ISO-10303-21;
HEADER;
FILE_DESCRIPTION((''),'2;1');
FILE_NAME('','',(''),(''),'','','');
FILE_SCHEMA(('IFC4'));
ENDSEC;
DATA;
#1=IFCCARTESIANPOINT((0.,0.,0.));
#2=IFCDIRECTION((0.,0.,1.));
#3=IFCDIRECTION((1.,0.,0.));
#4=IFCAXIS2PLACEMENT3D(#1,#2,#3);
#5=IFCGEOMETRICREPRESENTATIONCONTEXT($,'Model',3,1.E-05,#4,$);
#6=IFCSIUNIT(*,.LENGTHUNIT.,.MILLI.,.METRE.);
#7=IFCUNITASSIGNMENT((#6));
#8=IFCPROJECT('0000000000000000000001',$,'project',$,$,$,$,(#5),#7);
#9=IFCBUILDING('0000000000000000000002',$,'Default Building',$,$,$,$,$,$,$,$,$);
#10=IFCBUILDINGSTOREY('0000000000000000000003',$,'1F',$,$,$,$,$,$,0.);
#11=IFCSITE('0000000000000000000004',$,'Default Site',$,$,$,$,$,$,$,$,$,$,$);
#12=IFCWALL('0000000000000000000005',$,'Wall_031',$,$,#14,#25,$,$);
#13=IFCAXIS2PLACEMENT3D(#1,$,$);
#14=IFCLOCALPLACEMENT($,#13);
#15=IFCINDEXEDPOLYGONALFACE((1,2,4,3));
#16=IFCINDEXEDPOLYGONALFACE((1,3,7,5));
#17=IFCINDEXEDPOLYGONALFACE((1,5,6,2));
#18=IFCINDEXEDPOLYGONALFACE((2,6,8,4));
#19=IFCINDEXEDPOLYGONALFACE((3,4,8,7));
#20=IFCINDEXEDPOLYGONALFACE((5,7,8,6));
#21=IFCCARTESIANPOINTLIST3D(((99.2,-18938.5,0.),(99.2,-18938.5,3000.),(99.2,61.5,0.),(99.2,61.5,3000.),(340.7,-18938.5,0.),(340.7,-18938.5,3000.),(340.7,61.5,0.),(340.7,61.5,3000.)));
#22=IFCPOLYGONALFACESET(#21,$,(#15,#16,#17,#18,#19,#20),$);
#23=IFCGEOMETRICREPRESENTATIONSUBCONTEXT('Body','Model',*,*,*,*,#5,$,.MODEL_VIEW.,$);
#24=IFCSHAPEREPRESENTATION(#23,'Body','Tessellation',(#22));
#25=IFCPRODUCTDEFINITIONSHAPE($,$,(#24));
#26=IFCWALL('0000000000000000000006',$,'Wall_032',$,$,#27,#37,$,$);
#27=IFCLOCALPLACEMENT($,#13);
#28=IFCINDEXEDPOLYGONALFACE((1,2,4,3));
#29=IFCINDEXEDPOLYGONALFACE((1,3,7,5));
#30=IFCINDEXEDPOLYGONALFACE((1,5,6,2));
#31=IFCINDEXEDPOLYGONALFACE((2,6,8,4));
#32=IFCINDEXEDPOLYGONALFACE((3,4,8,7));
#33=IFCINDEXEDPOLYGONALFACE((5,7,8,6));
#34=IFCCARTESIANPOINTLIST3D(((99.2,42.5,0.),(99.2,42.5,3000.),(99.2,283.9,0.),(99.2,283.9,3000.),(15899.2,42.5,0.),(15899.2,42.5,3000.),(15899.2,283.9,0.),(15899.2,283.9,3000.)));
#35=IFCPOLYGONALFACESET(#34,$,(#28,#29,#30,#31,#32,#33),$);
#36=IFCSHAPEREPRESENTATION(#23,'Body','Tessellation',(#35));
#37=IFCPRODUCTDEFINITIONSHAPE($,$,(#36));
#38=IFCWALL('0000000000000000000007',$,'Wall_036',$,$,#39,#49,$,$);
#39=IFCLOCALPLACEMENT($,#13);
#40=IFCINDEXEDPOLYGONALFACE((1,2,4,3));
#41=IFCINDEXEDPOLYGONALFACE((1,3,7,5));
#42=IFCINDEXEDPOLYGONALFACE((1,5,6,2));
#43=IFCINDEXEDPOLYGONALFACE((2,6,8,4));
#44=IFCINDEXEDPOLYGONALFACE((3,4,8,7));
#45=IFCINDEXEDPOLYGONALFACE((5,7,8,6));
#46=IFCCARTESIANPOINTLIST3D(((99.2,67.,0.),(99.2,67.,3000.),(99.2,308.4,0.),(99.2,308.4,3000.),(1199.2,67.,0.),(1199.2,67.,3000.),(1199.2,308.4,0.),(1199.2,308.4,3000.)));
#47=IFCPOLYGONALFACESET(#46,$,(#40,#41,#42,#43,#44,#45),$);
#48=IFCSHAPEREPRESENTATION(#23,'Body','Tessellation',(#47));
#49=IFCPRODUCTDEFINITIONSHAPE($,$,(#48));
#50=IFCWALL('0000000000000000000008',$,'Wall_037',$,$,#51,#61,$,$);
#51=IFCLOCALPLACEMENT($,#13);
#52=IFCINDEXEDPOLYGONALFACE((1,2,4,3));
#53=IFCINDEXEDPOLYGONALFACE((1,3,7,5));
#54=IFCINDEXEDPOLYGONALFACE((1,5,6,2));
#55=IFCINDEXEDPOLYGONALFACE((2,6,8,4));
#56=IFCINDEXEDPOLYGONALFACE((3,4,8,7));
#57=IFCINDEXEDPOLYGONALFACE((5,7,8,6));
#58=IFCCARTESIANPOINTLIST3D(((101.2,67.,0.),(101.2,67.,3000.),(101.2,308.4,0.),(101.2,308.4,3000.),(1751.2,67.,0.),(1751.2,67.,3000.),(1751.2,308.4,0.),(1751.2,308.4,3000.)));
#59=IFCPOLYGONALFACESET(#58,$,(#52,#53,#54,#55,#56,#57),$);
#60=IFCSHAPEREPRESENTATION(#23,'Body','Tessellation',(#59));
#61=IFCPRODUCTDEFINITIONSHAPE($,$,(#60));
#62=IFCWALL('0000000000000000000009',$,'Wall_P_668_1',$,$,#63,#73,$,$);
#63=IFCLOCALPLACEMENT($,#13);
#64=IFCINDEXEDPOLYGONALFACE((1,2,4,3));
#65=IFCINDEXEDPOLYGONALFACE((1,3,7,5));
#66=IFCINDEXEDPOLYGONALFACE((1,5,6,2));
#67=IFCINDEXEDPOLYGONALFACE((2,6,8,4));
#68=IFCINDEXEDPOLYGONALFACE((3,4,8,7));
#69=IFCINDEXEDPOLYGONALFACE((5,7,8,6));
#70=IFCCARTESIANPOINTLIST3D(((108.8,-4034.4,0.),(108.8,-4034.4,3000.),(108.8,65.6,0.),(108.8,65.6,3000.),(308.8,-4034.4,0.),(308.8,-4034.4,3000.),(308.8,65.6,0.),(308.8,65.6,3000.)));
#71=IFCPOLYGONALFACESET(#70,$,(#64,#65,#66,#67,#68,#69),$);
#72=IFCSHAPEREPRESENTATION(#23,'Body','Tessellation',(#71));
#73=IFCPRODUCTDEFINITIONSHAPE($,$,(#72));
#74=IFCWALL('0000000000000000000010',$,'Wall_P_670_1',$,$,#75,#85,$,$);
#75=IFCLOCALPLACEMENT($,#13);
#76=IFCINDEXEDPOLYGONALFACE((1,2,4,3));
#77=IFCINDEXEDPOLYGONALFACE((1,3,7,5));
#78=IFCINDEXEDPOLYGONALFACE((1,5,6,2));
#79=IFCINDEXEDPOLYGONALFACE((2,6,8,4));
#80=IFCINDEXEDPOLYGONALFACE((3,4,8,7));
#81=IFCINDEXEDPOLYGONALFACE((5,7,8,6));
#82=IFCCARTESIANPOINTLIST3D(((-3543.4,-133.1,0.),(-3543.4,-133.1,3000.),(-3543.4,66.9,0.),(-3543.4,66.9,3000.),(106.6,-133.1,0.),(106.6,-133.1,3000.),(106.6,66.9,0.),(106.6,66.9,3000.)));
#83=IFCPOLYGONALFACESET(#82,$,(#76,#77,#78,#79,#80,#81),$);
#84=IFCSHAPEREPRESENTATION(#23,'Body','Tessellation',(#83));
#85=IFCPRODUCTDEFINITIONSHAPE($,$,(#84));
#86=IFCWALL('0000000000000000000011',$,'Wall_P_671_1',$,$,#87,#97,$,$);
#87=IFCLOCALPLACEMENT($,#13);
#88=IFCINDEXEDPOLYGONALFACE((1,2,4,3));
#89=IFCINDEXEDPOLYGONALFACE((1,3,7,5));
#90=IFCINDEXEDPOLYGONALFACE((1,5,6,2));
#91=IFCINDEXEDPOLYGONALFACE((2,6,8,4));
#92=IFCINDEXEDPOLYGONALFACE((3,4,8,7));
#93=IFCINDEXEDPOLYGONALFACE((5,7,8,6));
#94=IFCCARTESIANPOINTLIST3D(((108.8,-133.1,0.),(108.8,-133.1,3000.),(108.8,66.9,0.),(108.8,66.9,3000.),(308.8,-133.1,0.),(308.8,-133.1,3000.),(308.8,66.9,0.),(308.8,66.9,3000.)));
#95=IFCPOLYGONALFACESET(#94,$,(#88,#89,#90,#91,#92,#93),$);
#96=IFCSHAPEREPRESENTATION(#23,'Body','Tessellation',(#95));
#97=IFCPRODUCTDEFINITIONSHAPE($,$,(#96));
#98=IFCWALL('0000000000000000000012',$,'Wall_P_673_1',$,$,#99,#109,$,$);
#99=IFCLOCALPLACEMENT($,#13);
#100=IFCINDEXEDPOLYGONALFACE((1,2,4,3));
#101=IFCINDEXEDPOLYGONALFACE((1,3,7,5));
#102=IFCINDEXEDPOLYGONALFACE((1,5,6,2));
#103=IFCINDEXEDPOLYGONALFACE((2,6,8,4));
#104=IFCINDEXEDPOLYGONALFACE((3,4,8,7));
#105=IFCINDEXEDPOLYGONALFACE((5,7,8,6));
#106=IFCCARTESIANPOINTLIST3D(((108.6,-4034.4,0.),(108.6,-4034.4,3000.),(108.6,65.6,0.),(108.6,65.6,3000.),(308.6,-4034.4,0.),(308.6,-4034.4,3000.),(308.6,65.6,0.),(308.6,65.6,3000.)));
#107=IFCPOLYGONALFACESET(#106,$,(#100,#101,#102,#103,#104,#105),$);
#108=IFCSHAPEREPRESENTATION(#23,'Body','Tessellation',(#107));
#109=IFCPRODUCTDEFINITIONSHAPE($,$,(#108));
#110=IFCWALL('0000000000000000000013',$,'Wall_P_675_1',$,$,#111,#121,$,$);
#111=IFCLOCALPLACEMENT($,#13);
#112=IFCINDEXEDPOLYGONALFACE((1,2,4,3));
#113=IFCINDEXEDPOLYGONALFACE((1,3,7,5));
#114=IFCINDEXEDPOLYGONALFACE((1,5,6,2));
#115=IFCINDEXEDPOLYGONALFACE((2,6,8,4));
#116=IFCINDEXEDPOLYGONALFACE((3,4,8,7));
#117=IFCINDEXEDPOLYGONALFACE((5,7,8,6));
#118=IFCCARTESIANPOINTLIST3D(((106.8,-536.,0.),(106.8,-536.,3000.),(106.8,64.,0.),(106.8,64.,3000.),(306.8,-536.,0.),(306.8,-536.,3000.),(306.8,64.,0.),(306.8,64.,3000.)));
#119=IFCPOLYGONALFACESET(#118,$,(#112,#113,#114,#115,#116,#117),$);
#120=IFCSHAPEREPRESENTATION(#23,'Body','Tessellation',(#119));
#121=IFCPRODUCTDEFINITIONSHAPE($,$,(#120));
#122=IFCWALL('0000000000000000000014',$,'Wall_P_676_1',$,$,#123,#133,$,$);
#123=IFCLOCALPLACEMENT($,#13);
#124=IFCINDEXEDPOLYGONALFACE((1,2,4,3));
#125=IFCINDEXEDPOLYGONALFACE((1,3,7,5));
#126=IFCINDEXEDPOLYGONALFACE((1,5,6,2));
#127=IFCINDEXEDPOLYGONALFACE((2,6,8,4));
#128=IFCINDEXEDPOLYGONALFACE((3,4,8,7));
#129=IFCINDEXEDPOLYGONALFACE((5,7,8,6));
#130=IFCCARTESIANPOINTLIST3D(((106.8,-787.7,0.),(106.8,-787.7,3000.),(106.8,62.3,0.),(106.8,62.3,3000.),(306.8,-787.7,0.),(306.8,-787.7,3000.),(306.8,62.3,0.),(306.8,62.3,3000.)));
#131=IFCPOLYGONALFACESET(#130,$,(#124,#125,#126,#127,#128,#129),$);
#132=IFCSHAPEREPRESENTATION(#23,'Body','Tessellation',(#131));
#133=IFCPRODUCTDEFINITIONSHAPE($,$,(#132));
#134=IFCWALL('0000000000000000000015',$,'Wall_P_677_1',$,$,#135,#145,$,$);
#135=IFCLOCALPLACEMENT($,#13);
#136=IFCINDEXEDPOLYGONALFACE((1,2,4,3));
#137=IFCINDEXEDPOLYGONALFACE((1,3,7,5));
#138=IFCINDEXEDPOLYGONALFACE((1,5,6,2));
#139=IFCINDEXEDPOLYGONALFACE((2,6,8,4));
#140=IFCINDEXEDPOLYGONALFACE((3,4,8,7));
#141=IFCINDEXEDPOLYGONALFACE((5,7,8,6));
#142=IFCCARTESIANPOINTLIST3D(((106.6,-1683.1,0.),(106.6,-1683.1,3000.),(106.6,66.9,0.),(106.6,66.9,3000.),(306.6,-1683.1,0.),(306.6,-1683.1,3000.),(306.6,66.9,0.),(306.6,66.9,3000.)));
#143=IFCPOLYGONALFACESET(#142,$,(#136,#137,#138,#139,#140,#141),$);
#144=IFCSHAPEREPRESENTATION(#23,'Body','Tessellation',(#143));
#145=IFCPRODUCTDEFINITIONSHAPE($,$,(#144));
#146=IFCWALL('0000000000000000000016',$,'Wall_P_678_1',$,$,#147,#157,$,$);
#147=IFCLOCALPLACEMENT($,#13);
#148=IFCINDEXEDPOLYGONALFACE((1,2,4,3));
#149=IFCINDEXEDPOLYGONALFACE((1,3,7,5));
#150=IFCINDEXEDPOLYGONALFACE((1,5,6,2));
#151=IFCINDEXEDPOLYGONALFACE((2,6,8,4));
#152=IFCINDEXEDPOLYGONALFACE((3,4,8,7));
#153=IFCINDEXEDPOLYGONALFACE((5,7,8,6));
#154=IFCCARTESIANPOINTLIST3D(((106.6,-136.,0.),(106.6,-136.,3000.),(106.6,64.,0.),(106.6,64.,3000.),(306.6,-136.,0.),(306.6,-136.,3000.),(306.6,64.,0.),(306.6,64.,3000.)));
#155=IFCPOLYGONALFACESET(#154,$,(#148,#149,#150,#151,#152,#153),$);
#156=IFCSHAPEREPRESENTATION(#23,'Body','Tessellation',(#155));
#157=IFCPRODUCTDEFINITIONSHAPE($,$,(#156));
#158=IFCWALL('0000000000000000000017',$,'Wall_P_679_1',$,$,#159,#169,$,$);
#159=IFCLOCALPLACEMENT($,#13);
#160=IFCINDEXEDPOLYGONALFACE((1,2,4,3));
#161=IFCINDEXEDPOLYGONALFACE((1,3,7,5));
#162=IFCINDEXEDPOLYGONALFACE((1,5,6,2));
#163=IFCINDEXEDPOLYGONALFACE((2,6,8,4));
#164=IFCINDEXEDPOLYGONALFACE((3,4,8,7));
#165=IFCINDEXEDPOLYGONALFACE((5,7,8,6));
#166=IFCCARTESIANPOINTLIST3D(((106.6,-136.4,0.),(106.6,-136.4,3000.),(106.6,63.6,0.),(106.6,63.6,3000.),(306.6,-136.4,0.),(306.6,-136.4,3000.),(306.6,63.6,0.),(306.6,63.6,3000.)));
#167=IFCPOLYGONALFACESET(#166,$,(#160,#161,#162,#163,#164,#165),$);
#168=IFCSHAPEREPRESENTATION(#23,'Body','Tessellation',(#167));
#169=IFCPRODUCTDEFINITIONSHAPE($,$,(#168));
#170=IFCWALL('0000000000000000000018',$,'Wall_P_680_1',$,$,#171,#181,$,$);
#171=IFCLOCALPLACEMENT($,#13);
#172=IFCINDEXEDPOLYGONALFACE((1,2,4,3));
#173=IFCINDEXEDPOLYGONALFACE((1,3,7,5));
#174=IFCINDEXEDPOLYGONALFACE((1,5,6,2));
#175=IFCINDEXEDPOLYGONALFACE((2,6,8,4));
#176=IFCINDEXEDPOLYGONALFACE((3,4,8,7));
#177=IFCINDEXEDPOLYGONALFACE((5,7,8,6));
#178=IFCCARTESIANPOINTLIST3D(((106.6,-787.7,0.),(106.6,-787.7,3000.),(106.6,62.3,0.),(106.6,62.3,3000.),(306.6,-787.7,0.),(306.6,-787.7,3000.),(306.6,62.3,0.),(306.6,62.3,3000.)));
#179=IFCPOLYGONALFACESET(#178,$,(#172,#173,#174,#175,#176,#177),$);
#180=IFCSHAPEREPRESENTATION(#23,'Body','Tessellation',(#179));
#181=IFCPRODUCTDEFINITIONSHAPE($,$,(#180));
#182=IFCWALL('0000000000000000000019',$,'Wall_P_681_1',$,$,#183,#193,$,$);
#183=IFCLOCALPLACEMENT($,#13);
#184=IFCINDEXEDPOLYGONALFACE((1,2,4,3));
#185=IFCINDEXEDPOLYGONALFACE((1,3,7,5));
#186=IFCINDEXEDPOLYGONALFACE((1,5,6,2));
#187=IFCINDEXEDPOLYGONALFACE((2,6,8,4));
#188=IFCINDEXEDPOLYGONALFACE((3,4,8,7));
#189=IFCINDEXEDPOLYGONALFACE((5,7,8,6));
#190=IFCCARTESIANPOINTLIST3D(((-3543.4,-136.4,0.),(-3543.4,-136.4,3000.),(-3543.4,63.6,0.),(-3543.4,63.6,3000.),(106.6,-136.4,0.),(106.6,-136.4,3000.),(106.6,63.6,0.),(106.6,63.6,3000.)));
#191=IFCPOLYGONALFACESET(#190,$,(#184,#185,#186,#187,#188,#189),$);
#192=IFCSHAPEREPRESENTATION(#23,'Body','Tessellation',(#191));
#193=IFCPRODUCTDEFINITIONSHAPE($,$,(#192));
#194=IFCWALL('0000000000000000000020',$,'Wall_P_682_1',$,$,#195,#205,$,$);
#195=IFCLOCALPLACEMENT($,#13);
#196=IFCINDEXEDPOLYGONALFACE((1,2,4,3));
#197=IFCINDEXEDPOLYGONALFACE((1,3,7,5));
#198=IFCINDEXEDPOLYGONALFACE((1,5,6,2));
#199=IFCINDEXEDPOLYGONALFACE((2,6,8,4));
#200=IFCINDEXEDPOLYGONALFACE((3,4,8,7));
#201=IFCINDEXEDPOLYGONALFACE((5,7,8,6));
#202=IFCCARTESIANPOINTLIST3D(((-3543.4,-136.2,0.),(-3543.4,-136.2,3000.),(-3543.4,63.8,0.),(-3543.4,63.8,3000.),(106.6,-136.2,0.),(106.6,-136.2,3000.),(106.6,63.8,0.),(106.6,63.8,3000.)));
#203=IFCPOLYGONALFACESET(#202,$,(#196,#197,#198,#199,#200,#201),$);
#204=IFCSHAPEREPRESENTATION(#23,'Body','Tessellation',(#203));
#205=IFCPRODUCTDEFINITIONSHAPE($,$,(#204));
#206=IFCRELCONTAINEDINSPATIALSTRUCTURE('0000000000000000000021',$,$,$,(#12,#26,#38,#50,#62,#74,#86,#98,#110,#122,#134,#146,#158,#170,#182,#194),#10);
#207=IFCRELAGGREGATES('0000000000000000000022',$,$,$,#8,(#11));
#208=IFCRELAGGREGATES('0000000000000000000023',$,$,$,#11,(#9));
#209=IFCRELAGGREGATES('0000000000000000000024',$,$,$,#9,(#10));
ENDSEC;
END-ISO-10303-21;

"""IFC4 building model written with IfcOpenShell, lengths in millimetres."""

from ifc_helpers import new_model, si_unit, frame, origin_with_axes, place, context, subcontext, project, spatial, indexed_curve, outline, extrude, element, save


model = new_model("IFC4")

# Units and contexts
model_context = context("Model", 3, precision=1e-05, world=origin_with_axes())
body_context = subcontext(model_context, "Body", "Model", "MODEL_VIEW")
ifc_project = project(units=[si_unit("LENGTHUNIT", "METRE", prefix="MILLI")], contexts=[model_context])

# Site, building, storey
site = spatial("IfcSite", under=ifc_project, Name="Default Site")
building = spatial("IfcBuilding", under=site, Name="Default Building")
storey = spatial("IfcBuildingStorey", under=building, Name="1F", Elevation=0.0)

# Walls
wall_1_placement = place(None, frame((99.2, 61.5, 0.0), z_axis=(0.0, 0.0, 1.0), x_axis=(0.0, -1.0, 0.0)))
element("IfcWall", 1, at=wall_1_placement, inside=storey, Name="Wall_031", context=body_context, shape_type="SweptSolid", body=[
    extrude(outline(indexed_curve([(0.0, 0.0), (0.0, 241.4), (19000.0, 241.4), (19000.0, 0.0), (0.0, 0.0)], self_intersect=False)), origin_with_axes(), (0.0, 0.0, 1.0), 3000.0),
])
wall_2_placement = place(None, frame((99.2, 42.5, 0.0), z_axis=(0.0, 0.0, 1.0), x_axis=(1.0, 0.0, 0.0)))
element("IfcWall", 2, at=wall_2_placement, inside=storey, Name="Wall_032", context=body_context, shape_type="SweptSolid", body=[
    extrude(outline(indexed_curve([(0.0, 0.0), (0.0, 241.4), (15800.0, 241.4), (15800.0, 0.0), (0.0, 0.0)], self_intersect=False)), origin_with_axes(), (0.0, 0.0, 1.0), 3000.0),
])
wall_3_placement = place(None, frame((99.2, 67.0, 0.0), z_axis=(0.0, 0.0, 1.0), x_axis=(1.0, 0.0, 0.0)))
element("IfcWall", 3, at=wall_3_placement, inside=storey, Name="Wall_036", context=body_context, shape_type="SweptSolid", body=[
    extrude(outline(indexed_curve([(0.0, 0.0), (0.0, 241.4), (1100.0, 241.4), (1100.0, 0.0), (0.0, 0.0)], self_intersect=False)), origin_with_axes(), (0.0, 0.0, 1.0), 3000.0),
])
wall_4_placement = place(None, frame((101.2, 67.0, 0.0), z_axis=(0.0, 0.0, 1.0), x_axis=(1.0, 0.0, 0.0)))
element("IfcWall", 4, at=wall_4_placement, inside=storey, Name="Wall_037", context=body_context, shape_type="SweptSolid", body=[
    extrude(outline(indexed_curve([(0.0, 0.0), (0.0, 241.4), (1650.0, 241.4), (1650.0, 0.0), (0.0, 0.0)], self_intersect=False)), origin_with_axes(), (0.0, 0.0, 1.0), 3000.0),
])
wall_5_placement = place(None, frame((108.8, 65.6, 0.0), z_axis=(0.0, 0.0, 1.0), x_axis=(0.0, -1.0, 0.0)))
element("IfcWall", 5, at=wall_5_placement, inside=storey, Name="Wall_P_668_1", context=body_context, shape_type="SweptSolid", body=[
    extrude(outline(indexed_curve([(0.0, 0.0), (0.0, 200.0), (4100.0, 200.0), (4100.0, 0.0), (0.0, 0.0)], self_intersect=False)), origin_with_axes(), (0.0, 0.0, 1.0), 3000.0),
])
wall_6_placement = place(None, frame((106.6, 66.9, 0.0), z_axis=(0.0, 0.0, 1.0), x_axis=(-1.0, 0.0, 0.0)))
element("IfcWall", 6, at=wall_6_placement, inside=storey, Name="Wall_P_670_1", context=body_context, shape_type="SweptSolid", body=[
    extrude(outline(indexed_curve([(0.0, 0.0), (0.0, 200.0), (3650.0, 200.0), (3650.0, 0.0), (0.0, 0.0)], self_intersect=False)), origin_with_axes(), (0.0, 0.0, 1.0), 3000.0),
])
wall_7_placement = place(None, frame((108.8, 66.9, 0.0), z_axis=(0.0, 0.0, 1.0), x_axis=(0.0, -1.0, 0.0)))
element("IfcWall", 7, at=wall_7_placement, inside=storey, Name="Wall_P_671_1", context=body_context, shape_type="SweptSolid", body=[
    extrude(outline(indexed_curve([(0.0, 0.0), (0.0, 200.0), (200.0, 200.0), (200.0, 0.0), (0.0, 0.0)], self_intersect=False)), origin_with_axes(), (0.0, 0.0, 1.0), 3000.0),
])
wall_8_placement = place(None, frame((108.6, 65.6, 0.0), z_axis=(0.0, 0.0, 1.0), x_axis=(0.0, -1.0, 0.0)))
element("IfcWall", 8, at=wall_8_placement, inside=storey, Name="Wall_P_673_1", context=body_context, shape_type="SweptSolid", body=[
    extrude(outline(indexed_curve([(0.0, 0.0), (0.0, 200.0), (4100.0, 200.0), (4100.0, 0.0), (0.0, 0.0)], self_intersect=False)), origin_with_axes(), (0.0, 0.0, 1.0), 3000.0),
])
wall_9_placement = place(None, frame((106.8, 64.0, 0.0), z_axis=(0.0, 0.0, 1.0), x_axis=(0.0, -1.0, 0.0)))
element("IfcWall", 9, at=wall_9_placement, inside=storey, Name="Wall_P_675_1", context=body_context, shape_type="SweptSolid", body=[
    extrude(outline(indexed_curve([(0.0, 0.0), (0.0, 200.0), (600.0, 200.0), (600.0, 0.0), (0.0, 0.0)], self_intersect=False)), origin_with_axes(), (0.0, 0.0, 1.0), 3000.0),
])
wall_10_placement = place(None, frame((106.8, 62.3, 0.0), z_axis=(0.0, 0.0, 1.0), x_axis=(0.0, -1.0, 0.0)))
element("IfcWall", 10, at=wall_10_placement, inside=storey, Name="Wall_P_676_1", context=body_context, shape_type="SweptSolid", body=[
    extrude(outline(indexed_curve([(0.0, 0.0), (0.0, 200.0), (850.0, 200.0), (850.0, 0.0), (0.0, 0.0)], self_intersect=False)), origin_with_axes(), (0.0, 0.0, 1.0), 3000.0),
])
wall_11_placement = place(None, frame((106.6, 66.9, 0.0), z_axis=(0.0, 0.0, 1.0), x_axis=(0.0, -1.0, 0.0)))
element("IfcWall", 11, at=wall_11_placement, inside=storey, Name="Wall_P_677_1", context=body_context, shape_type="SweptSolid", body=[
    extrude(outline(indexed_curve([(0.0, 0.0), (0.0, 200.0), (1750.0, 200.0), (1750.0, 0.0), (0.0, 0.0)], self_intersect=False)), origin_with_axes(), (0.0, 0.0, 1.0), 3000.0),
])
wall_12_placement = place(None, frame((106.6, 64.0, 0.0), z_axis=(0.0, 0.0, 1.0), x_axis=(0.0, -1.0, 0.0)))
element("IfcWall", 12, at=wall_12_placement, inside=storey, Name="Wall_P_678_1", context=body_context, shape_type="SweptSolid", body=[
    extrude(outline(indexed_curve([(0.0, 0.0), (0.0, 200.0), (200.0, 200.0), (200.0, 0.0), (0.0, 0.0)], self_intersect=False)), origin_with_axes(), (0.0, 0.0, 1.0), 3000.0),
])
wall_13_placement = place(None, frame((106.6, 63.6, 0.0), z_axis=(0.0, 0.0, 1.0), x_axis=(0.0, -1.0, 0.0)))
element("IfcWall", 13, at=wall_13_placement, inside=storey, Name="Wall_P_679_1", context=body_context, shape_type="SweptSolid", body=[
    extrude(outline(indexed_curve([(0.0, 0.0), (0.0, 200.0), (200.0, 200.0), (200.0, 0.0), (0.0, 0.0)], self_intersect=False)), origin_with_axes(), (0.0, 0.0, 1.0), 3000.0),
])
wall_14_placement = place(None, frame((106.6, 62.3, 0.0), z_axis=(0.0, 0.0, 1.0), x_axis=(0.0, -1.0, 0.0)))
element("IfcWall", 14, at=wall_14_placement, inside=storey, Name="Wall_P_680_1", context=body_context, shape_type="SweptSolid", body=[
    extrude(outline(indexed_curve([(0.0, 0.0), (0.0, 200.0), (850.0, 200.0), (850.0, 0.0), (0.0, 0.0)], self_intersect=False)), origin_with_axes(), (0.0, 0.0, 1.0), 3000.0),
])
for number, where, z_axis, x_axis, name in (
    (15, (106.6, 63.6, 0.0), (0.0, 0.0, 1.0), (-1.0, 0.0, 0.0), "Wall_P_681_1"),
    (16, (106.6, 63.8, 0.0), (0.0, 0.0, 1.0), (-1.0, 0.0, 0.0), "Wall_P_682_1"),
):
    element("IfcWall", number, at=place(None, frame(where, z_axis=z_axis, x_axis=x_axis)), inside=storey, Name=name, context=body_context, shape_type="SweptSolid", body=[
        extrude(outline(indexed_curve([(0.0, 0.0), (0.0, 200.0), (3650.0, 200.0), (3650.0, 0.0), (0.0, 0.0)], self_intersect=False)), origin_with_axes(), (0.0, 0.0, 1.0), 3000.0),
    ])

save(model, "model.ifc")
